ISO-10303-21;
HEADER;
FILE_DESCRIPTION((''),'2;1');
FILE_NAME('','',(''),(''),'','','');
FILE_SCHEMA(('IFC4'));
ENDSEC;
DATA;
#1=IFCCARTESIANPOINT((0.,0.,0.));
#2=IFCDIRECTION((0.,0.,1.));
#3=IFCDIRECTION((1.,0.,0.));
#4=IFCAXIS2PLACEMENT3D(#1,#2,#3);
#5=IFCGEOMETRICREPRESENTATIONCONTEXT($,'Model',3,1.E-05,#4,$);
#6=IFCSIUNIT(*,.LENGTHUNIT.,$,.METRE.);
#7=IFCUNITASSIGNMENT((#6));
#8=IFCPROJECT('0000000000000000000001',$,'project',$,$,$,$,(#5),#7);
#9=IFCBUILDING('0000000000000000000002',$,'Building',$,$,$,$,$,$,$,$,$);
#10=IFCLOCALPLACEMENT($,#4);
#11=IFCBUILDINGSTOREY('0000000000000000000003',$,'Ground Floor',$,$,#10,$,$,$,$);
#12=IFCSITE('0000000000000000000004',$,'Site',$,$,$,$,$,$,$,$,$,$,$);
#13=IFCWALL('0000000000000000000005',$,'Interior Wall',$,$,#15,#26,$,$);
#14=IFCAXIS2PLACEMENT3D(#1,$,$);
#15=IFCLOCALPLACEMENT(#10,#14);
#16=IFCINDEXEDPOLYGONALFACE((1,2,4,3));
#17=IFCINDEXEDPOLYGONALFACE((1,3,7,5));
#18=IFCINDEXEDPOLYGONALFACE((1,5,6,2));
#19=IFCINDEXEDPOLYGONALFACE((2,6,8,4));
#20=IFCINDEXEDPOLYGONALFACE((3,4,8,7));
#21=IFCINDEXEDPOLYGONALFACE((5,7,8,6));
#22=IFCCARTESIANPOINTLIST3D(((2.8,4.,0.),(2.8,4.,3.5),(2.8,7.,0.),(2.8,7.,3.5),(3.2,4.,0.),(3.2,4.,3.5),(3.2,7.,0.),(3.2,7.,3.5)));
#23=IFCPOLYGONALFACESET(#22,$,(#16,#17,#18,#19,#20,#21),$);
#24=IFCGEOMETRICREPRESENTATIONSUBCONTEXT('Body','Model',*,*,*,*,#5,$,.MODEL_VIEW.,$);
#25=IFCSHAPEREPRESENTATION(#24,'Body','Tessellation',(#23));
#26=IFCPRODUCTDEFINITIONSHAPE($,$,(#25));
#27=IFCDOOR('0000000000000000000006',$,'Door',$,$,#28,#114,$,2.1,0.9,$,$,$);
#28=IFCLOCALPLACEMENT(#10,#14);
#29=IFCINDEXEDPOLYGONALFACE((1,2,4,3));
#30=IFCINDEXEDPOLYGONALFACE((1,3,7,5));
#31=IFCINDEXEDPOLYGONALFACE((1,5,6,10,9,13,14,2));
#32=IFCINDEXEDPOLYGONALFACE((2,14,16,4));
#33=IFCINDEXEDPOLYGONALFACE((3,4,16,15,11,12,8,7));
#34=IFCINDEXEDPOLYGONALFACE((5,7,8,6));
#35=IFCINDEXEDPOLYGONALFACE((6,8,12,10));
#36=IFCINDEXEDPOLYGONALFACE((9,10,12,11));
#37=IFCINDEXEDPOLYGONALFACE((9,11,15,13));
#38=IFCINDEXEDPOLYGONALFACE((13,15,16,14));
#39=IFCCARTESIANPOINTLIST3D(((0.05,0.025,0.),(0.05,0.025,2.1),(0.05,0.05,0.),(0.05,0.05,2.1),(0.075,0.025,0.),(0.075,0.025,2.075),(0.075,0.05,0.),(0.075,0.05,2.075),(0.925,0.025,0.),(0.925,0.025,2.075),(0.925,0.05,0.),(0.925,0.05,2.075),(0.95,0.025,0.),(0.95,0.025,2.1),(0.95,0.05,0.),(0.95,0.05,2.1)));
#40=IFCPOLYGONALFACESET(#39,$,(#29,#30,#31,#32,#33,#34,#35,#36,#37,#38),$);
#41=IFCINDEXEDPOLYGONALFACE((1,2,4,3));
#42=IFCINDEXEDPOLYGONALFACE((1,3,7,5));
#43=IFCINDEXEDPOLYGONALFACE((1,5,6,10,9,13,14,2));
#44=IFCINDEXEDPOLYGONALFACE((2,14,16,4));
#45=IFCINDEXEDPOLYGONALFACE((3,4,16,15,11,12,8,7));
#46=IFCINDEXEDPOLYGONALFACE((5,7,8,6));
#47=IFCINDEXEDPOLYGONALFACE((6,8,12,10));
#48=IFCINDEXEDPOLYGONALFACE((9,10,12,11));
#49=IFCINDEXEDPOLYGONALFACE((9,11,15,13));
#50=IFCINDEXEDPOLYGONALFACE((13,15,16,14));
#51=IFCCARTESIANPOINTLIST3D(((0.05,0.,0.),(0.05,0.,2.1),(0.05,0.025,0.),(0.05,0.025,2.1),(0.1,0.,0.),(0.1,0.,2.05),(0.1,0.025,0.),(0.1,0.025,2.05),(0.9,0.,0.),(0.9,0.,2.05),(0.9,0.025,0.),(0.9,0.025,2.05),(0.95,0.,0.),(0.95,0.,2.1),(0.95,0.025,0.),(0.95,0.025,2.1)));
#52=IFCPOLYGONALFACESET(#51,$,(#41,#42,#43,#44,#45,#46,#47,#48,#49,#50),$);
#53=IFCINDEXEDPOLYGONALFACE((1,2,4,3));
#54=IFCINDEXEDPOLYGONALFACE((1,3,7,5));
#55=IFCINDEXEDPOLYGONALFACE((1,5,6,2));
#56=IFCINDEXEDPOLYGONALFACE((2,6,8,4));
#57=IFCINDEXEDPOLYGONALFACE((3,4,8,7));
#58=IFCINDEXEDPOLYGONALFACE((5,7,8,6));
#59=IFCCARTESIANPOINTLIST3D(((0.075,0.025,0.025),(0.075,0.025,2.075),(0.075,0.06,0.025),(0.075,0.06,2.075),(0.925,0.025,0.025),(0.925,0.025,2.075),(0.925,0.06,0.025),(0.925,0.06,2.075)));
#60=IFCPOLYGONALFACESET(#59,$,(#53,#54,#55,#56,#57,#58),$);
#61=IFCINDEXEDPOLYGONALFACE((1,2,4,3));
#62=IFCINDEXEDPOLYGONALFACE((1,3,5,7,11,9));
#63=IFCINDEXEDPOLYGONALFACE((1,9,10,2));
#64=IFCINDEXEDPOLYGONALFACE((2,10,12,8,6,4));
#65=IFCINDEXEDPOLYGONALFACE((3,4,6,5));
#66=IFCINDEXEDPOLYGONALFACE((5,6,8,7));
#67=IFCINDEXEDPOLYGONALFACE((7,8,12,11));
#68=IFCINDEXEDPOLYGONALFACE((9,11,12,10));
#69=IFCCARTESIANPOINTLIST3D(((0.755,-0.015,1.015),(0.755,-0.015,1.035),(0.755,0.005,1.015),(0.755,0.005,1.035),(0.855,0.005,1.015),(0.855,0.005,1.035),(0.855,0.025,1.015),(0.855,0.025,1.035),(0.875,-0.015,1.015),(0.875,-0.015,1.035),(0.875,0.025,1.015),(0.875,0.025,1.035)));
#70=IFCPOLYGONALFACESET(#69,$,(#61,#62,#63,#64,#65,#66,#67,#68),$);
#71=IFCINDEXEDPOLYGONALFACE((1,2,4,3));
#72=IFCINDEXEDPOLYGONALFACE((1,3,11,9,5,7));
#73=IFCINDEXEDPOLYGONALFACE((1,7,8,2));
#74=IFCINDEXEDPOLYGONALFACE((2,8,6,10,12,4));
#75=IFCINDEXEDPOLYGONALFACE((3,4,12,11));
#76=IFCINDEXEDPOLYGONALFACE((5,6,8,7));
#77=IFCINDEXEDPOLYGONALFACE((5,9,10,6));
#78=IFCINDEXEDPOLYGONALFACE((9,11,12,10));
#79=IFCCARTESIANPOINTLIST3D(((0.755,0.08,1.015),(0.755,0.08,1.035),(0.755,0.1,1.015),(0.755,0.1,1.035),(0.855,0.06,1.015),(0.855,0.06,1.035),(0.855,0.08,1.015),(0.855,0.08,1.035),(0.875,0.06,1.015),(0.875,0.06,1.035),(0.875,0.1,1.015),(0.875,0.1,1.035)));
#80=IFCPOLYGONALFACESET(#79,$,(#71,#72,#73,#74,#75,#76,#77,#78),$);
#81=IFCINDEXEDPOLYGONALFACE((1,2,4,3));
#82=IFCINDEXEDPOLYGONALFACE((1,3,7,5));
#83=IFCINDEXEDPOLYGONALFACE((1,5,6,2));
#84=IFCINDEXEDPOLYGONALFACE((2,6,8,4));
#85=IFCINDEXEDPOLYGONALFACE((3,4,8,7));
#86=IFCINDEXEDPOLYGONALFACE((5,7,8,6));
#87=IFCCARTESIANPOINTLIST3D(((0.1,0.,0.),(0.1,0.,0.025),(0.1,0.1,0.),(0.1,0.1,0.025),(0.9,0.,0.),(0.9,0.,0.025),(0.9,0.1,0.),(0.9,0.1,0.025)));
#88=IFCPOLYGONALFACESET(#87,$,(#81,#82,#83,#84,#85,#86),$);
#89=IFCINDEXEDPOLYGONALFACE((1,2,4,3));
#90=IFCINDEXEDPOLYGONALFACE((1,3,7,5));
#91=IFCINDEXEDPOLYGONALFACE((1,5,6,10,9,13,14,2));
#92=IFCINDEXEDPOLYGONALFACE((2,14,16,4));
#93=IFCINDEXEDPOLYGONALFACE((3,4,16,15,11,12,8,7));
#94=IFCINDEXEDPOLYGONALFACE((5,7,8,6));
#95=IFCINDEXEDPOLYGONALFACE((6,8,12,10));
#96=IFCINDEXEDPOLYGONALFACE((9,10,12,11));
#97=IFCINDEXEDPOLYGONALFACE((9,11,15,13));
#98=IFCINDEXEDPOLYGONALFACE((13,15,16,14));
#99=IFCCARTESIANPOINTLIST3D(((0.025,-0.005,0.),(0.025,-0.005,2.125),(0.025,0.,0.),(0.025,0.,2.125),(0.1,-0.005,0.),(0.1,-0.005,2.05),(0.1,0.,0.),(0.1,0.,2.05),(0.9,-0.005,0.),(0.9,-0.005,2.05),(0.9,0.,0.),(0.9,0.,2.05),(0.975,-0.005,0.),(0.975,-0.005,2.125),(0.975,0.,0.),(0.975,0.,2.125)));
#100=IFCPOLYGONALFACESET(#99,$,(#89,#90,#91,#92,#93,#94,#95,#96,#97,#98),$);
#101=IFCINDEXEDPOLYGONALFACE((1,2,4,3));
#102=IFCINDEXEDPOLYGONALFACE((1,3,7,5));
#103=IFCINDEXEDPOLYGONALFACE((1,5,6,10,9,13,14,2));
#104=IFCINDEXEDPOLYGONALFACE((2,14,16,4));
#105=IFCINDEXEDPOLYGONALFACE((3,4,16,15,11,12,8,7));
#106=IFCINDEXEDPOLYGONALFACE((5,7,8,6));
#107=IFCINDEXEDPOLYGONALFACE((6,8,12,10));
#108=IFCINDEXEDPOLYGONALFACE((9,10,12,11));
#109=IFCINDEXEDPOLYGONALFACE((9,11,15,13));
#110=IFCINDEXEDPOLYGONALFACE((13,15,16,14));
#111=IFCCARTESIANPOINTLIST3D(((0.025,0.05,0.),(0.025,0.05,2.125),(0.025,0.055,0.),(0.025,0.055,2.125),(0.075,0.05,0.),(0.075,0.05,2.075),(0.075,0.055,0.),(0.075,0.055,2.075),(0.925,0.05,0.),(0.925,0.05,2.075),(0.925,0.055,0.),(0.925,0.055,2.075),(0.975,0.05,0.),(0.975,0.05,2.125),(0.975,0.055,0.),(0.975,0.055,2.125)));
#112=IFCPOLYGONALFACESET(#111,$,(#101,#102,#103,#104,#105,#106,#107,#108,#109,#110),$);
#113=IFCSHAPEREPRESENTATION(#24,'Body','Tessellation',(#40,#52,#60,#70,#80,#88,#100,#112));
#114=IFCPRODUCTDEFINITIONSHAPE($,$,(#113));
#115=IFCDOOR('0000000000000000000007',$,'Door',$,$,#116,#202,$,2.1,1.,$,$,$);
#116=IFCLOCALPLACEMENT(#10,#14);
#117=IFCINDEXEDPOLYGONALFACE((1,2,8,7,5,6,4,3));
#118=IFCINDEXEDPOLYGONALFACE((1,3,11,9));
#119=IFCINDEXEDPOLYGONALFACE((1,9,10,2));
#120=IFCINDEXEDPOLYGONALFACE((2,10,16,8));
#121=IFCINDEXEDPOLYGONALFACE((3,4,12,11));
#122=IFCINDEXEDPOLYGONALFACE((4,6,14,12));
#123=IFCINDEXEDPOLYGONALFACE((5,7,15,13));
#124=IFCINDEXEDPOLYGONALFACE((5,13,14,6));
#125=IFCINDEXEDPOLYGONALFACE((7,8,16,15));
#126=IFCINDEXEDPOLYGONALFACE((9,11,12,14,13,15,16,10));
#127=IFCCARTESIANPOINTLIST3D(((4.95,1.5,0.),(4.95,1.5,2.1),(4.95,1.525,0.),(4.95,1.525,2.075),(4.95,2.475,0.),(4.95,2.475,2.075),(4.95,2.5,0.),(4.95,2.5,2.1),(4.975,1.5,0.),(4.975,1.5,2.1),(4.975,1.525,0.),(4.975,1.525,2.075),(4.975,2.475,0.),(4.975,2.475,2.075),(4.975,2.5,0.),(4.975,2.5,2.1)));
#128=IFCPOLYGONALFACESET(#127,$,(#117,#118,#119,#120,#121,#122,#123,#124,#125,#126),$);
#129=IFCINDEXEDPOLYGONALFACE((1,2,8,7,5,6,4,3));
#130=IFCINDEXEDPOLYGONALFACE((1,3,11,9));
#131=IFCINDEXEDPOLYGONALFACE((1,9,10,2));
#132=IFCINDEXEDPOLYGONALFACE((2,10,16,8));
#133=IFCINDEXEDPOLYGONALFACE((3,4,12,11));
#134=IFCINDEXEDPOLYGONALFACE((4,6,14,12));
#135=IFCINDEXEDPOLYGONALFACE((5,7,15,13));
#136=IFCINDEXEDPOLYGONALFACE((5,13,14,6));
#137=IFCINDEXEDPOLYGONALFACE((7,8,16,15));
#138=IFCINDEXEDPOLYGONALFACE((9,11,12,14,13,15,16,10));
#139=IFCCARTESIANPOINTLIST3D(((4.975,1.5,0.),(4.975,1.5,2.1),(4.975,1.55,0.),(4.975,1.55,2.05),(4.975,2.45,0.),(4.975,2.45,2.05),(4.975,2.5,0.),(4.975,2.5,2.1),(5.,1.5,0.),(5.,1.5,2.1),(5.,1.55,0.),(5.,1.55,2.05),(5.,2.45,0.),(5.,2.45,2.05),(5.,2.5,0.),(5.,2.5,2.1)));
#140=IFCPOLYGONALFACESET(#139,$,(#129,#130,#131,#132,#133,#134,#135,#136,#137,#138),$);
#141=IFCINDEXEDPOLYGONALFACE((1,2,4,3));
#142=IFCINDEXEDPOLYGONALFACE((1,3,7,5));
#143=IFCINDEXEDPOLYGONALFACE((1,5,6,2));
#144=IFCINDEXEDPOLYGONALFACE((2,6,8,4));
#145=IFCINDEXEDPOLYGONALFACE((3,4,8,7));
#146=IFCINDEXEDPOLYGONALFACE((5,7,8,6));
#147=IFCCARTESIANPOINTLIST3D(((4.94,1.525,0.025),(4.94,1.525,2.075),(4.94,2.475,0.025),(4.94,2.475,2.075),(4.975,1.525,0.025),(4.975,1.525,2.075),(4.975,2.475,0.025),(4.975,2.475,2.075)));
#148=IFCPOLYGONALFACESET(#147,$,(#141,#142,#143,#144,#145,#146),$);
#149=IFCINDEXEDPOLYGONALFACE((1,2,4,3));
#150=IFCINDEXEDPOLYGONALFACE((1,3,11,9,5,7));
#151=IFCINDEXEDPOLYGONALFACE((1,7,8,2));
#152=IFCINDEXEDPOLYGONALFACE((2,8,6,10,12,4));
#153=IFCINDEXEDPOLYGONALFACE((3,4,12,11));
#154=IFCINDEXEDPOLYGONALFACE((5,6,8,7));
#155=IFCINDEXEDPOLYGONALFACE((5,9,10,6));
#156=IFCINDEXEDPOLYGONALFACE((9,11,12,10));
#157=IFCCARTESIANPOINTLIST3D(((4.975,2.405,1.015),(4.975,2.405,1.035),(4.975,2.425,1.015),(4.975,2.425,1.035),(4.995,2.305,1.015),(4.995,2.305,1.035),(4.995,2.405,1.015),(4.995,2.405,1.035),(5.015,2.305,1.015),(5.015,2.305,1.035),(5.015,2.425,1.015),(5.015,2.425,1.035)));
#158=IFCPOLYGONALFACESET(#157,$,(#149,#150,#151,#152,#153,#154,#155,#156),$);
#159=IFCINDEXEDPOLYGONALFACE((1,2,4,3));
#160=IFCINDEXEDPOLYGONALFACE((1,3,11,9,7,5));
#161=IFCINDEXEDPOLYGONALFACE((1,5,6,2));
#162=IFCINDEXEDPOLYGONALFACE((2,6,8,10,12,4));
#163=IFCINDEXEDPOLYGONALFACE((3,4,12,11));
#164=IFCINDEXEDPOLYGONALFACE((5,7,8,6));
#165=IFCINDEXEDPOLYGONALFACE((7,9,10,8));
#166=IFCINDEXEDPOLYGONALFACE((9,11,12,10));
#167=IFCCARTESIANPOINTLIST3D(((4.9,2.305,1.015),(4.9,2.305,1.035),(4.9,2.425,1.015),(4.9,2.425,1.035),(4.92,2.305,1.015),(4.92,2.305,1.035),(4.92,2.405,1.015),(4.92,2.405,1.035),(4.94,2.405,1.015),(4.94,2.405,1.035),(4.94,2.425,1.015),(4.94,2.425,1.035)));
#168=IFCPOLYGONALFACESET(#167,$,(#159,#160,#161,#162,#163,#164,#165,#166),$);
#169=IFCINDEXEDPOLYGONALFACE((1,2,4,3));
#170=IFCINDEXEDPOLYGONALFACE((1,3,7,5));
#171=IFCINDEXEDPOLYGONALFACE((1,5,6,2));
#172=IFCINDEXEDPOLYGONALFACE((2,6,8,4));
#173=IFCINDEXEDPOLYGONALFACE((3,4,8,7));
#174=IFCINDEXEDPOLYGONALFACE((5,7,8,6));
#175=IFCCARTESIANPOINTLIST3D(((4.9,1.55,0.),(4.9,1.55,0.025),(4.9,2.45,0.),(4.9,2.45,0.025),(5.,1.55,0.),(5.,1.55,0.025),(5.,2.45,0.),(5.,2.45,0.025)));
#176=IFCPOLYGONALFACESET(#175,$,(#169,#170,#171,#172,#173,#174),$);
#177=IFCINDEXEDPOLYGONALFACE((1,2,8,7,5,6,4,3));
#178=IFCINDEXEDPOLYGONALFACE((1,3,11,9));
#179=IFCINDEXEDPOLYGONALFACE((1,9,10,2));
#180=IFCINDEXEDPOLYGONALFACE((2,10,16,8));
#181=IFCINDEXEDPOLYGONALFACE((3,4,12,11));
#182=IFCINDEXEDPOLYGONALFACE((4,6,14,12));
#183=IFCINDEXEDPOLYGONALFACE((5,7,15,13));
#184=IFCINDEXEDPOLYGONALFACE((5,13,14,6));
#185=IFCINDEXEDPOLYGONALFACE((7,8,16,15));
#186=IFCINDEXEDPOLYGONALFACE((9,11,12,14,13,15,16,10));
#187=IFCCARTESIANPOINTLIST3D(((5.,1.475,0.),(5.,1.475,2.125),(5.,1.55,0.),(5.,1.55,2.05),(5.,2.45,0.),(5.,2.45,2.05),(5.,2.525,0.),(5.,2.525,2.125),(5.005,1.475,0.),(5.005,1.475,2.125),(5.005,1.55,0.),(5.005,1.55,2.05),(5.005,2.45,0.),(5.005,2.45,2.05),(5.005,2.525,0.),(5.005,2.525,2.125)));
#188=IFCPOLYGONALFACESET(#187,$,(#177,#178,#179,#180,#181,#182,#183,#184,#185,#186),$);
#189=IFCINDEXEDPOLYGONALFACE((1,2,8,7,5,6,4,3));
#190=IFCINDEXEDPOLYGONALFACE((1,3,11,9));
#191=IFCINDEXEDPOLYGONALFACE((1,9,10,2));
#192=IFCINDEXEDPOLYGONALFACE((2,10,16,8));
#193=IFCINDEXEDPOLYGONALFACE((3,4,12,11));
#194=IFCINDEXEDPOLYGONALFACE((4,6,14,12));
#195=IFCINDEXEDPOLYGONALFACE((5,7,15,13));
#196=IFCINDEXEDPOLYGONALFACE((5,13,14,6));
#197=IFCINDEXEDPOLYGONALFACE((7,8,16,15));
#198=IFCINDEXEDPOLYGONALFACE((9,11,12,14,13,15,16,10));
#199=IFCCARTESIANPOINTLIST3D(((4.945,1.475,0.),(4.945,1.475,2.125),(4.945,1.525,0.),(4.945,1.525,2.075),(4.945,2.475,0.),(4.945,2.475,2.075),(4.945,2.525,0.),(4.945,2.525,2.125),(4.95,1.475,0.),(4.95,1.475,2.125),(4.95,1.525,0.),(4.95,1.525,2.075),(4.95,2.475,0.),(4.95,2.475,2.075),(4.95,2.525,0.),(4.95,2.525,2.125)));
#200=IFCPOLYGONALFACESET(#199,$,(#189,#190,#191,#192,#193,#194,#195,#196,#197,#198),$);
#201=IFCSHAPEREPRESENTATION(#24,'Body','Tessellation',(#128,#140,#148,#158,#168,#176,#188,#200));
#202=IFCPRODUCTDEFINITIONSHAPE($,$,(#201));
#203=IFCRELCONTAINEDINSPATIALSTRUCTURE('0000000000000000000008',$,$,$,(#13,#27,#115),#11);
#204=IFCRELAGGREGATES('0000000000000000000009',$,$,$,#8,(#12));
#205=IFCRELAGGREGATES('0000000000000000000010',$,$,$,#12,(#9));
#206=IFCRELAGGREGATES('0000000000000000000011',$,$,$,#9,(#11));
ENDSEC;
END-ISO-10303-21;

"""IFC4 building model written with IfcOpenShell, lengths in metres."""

from ifc_helpers import new_model, si_unit, frame, origin_with_axes, place, context, subcontext, project, spatial, line, indexed_curve, outline, extrude, element, save


model = new_model("IFC4")

# Units and contexts
model_context = context("Model", 3, precision=1e-05, world=origin_with_axes())
body_context = subcontext(model_context, "Body", "Model", "MODEL_VIEW")
ifc_project = project(units=[si_unit("LENGTHUNIT", "METRE")], contexts=[model_context])

# Site, building, storey
site = spatial("IfcSite", under=ifc_project, Name="Site")
building = spatial("IfcBuilding", under=site, Name="Building")
storey_placement = place(None, origin_with_axes())
storey = spatial("IfcBuildingStorey", under=building, at=storey_placement, Name="Ground Floor")

# Wall
wall_1_placement = place(storey_placement, frame((3.0, 4.0, 0.0), z_axis=(0.0, 0.0, 1.0), x_axis=(0.0, 1.0, 0.0)))
element("IfcWall", 1, at=wall_1_placement, inside=storey, Name="Interior Wall", context=body_context, shape_type="SweptSolid", body=[
    extrude(outline(indexed_curve([(0.0, 0.0), (0.0, 0.4), (3.0, 0.4), (3.0, 0.0), (0.0, 0.0)], self_intersect=False)), frame((0.0, -0.2, 0.0), z_axis=(0.0, 0.0, 1.0), x_axis=(1.0, 0.0, 0.0)), (0.0, 0.0, 1.0), 3.5),
])

# Doors
door_1_placement = place(storey_placement, frame((0.05, 0.0, 0.0), z_axis=(0.0, 0.0, 1.0), x_axis=(1.0, 0.0, 0.0)))
element("IfcDoor", 2, at=door_1_placement, inside=storey, Name="Door", OverallHeight=2.1, OverallWidth=0.9, context=body_context, shape_type="SweptSolid", body=[
    extrude(outline(indexed_curve([(0.0, 0.0), (0.0, 2.1), (0.9, 2.1), (0.9, 0.0), (0.875, 0.0), (0.875, 2.075), (0.025, 2.075), (0.025, 0.0)], segments=[line(1, 2, 3, 4, 5, 6, 7, 8, 1)])), frame((0.0, 0.025, 0.0), z_axis=(0.0, -1.0, 0.0), x_axis=(1.0, 0.0, 0.0)), (0.0, 0.0, -1.0), 0.025),
    extrude(outline(indexed_curve([(0.0, 0.0), (0.0, 2.1), (0.9, 2.1), (0.9, 0.0), (0.85, 0.0), (0.85, 2.05), (0.05, 2.05), (0.05, 0.0)], segments=[line(1, 2, 3, 4, 5, 6, 7, 8, 1)])), frame((0.0, 0.0, 0.0), z_axis=(0.0, -1.0, 0.0), x_axis=(1.0, 0.0, 0.0)), (0.0, 0.0, -1.0), 0.025),
    extrude(outline(indexed_curve([(0.0, 0.0), (0.85, 0.0), (0.85, 0.035), (0.0, 0.035)], segments=[line(1, 2, 3, 4, 1)])), frame((0.025, 0.025, 0.025), z_axis=(0.0, 0.0, 1.0), x_axis=(1.0, 0.0, 0.0)), (0.0, 0.0, 1.0), 2.05),
    extrude(outline(indexed_curve([(0.0, 0.0), (0.0, -0.04), (-0.12, -0.04), (-0.12, -0.02), (-0.02, -0.02), (-0.02, 0.0)], segments=[line(1, 2, 3, 4, 5, 6, 1)])), frame((0.825, 0.025, 1.015), z_axis=(0.0, 0.0, 1.0), x_axis=(1.0, 0.0, 0.0)), (0.0, 0.0, 1.0), 0.02),
    extrude(outline(indexed_curve([(0.0, 0.0), (0.0, 0.04), (-0.12, 0.04), (-0.12, 0.02), (-0.02, 0.02), (-0.02, 0.0)], segments=[line(1, 2, 3, 4, 5, 6, 1)])), frame((0.825, 0.06, 1.015), z_axis=(0.0, 0.0, 1.0), x_axis=(1.0, 0.0, 0.0)), (0.0, 0.0, 1.0), 0.02),
    extrude(outline(indexed_curve([(0.0, 0.0), (0.8, 0.0), (0.8, 0.1), (0.0, 0.1)], segments=[line(1, 2, 3, 4, 1)])), frame((0.05, 0.0, 0.0), z_axis=(0.0, 0.0, 1.0), x_axis=(1.0, 0.0, 0.0)), (0.0, 0.0, 1.0), 0.025),
    extrude(outline(indexed_curve([(0.0, 0.0), (0.0, 2.125), (0.95, 2.125), (0.95, 0.0), (0.875, 0.0), (0.875, 2.05), (0.075, 2.05), (0.075, 0.0)], segments=[line(1, 2, 3, 4, 5, 6, 7, 8, 1)])), frame((-0.025, -0.005, 0.0), z_axis=(0.0, -1.0, 0.0), x_axis=(1.0, 0.0, 0.0)), (0.0, 0.0, -1.0), 0.005),
    extrude(outline(indexed_curve([(0.0, 0.0), (0.0, 2.125), (0.95, 2.125), (0.95, 0.0), (0.9, 0.0), (0.9, 2.075), (0.05, 2.075), (0.05, 0.0)], segments=[line(1, 2, 3, 4, 5, 6, 7, 8, 1)])), frame((-0.025, 0.05, 0.0), z_axis=(0.0, -1.0, 0.0), x_axis=(1.0, 0.0, 0.0)), (0.0, 0.0, -1.0), 0.005),
])
door_2_placement = place(storey_placement, frame((5.0, 1.5, 0.0), z_axis=(0.0, 0.0, 1.0), x_axis=(0.0, 1.0, 0.0)))
element("IfcDoor", 3, at=door_2_placement, inside=storey, Name="Door", OverallHeight=2.1, OverallWidth=1.0, context=body_context, shape_type="SweptSolid", body=[
    extrude(outline(indexed_curve([(0.0, 0.0), (0.0, 2.1), (1.0, 2.1), (1.0, 0.0), (0.975, 0.0), (0.975, 2.075), (0.025, 2.075), (0.025, 0.0)], segments=[line(1, 2, 3, 4, 5, 6, 7, 8, 1)])), frame((0.0, 0.025, 0.0), z_axis=(0.0, -1.0, 0.0), x_axis=(1.0, 0.0, 0.0)), (0.0, 0.0, -1.0), 0.025),
    extrude(outline(indexed_curve([(0.0, 0.0), (0.0, 2.1), (1.0, 2.1), (1.0, 0.0), (0.95, 0.0), (0.95, 2.05), (0.05, 2.05), (0.05, 0.0)], segments=[line(1, 2, 3, 4, 5, 6, 7, 8, 1)])), frame((0.0, 0.0, 0.0), z_axis=(0.0, -1.0, 0.0), x_axis=(1.0, 0.0, 0.0)), (0.0, 0.0, -1.0), 0.025),
    extrude(outline(indexed_curve([(0.0, 0.0), (0.95, 0.0), (0.95, 0.035), (0.0, 0.035)], segments=[line(1, 2, 3, 4, 1)])), frame((0.025, 0.025, 0.025), z_axis=(0.0, 0.0, 1.0), x_axis=(1.0, 0.0, 0.0)), (0.0, 0.0, 1.0), 2.05),
    extrude(outline(indexed_curve([(0.0, 0.0), (0.0, -0.04), (-0.12, -0.04), (-0.12, -0.02), (-0.02, -0.02), (-0.02, 0.0)], segments=[line(1, 2, 3, 4, 5, 6, 1)])), frame((0.925, 0.025, 1.015), z_axis=(0.0, 0.0, 1.0), x_axis=(1.0, 0.0, 0.0)), (0.0, 0.0, 1.0), 0.02),
    extrude(outline(indexed_curve([(0.0, 0.0), (0.0, 0.04), (-0.12, 0.04), (-0.12, 0.02), (-0.02, 0.02), (-0.02, 0.0)], segments=[line(1, 2, 3, 4, 5, 6, 1)])), frame((0.925, 0.06, 1.015), z_axis=(0.0, 0.0, 1.0), x_axis=(1.0, 0.0, 0.0)), (0.0, 0.0, 1.0), 0.02),
    extrude(outline(indexed_curve([(0.0, 0.0), (0.9, 0.0), (0.9, 0.1), (0.0, 0.1)], segments=[line(1, 2, 3, 4, 1)])), frame((0.05, 0.0, 0.0), z_axis=(0.0, 0.0, 1.0), x_axis=(1.0, 0.0, 0.0)), (0.0, 0.0, 1.0), 0.025),
    extrude(outline(indexed_curve([(0.0, 0.0), (0.0, 2.125), (1.05, 2.125), (1.05, 0.0), (0.975, 0.0), (0.975, 2.05), (0.075, 2.05), (0.075, 0.0)], segments=[line(1, 2, 3, 4, 5, 6, 7, 8, 1)])), frame((-0.025, -0.005, 0.0), z_axis=(0.0, -1.0, 0.0), x_axis=(1.0, 0.0, 0.0)), (0.0, 0.0, -1.0), 0.005),
    extrude(outline(indexed_curve([(0.0, 0.0), (0.0, 2.125), (1.05, 2.125), (1.05, 0.0), (1.0, 0.0), (1.0, 2.075), (0.05, 2.075), (0.05, 0.0)], segments=[line(1, 2, 3, 4, 5, 6, 7, 8, 1)])), frame((-0.025, 0.05, 0.0), z_axis=(0.0, -1.0, 0.0), x_axis=(1.0, 0.0, 0.0)), (0.0, 0.0, -1.0), 0.005),
])

save(model, "model.ifc")
